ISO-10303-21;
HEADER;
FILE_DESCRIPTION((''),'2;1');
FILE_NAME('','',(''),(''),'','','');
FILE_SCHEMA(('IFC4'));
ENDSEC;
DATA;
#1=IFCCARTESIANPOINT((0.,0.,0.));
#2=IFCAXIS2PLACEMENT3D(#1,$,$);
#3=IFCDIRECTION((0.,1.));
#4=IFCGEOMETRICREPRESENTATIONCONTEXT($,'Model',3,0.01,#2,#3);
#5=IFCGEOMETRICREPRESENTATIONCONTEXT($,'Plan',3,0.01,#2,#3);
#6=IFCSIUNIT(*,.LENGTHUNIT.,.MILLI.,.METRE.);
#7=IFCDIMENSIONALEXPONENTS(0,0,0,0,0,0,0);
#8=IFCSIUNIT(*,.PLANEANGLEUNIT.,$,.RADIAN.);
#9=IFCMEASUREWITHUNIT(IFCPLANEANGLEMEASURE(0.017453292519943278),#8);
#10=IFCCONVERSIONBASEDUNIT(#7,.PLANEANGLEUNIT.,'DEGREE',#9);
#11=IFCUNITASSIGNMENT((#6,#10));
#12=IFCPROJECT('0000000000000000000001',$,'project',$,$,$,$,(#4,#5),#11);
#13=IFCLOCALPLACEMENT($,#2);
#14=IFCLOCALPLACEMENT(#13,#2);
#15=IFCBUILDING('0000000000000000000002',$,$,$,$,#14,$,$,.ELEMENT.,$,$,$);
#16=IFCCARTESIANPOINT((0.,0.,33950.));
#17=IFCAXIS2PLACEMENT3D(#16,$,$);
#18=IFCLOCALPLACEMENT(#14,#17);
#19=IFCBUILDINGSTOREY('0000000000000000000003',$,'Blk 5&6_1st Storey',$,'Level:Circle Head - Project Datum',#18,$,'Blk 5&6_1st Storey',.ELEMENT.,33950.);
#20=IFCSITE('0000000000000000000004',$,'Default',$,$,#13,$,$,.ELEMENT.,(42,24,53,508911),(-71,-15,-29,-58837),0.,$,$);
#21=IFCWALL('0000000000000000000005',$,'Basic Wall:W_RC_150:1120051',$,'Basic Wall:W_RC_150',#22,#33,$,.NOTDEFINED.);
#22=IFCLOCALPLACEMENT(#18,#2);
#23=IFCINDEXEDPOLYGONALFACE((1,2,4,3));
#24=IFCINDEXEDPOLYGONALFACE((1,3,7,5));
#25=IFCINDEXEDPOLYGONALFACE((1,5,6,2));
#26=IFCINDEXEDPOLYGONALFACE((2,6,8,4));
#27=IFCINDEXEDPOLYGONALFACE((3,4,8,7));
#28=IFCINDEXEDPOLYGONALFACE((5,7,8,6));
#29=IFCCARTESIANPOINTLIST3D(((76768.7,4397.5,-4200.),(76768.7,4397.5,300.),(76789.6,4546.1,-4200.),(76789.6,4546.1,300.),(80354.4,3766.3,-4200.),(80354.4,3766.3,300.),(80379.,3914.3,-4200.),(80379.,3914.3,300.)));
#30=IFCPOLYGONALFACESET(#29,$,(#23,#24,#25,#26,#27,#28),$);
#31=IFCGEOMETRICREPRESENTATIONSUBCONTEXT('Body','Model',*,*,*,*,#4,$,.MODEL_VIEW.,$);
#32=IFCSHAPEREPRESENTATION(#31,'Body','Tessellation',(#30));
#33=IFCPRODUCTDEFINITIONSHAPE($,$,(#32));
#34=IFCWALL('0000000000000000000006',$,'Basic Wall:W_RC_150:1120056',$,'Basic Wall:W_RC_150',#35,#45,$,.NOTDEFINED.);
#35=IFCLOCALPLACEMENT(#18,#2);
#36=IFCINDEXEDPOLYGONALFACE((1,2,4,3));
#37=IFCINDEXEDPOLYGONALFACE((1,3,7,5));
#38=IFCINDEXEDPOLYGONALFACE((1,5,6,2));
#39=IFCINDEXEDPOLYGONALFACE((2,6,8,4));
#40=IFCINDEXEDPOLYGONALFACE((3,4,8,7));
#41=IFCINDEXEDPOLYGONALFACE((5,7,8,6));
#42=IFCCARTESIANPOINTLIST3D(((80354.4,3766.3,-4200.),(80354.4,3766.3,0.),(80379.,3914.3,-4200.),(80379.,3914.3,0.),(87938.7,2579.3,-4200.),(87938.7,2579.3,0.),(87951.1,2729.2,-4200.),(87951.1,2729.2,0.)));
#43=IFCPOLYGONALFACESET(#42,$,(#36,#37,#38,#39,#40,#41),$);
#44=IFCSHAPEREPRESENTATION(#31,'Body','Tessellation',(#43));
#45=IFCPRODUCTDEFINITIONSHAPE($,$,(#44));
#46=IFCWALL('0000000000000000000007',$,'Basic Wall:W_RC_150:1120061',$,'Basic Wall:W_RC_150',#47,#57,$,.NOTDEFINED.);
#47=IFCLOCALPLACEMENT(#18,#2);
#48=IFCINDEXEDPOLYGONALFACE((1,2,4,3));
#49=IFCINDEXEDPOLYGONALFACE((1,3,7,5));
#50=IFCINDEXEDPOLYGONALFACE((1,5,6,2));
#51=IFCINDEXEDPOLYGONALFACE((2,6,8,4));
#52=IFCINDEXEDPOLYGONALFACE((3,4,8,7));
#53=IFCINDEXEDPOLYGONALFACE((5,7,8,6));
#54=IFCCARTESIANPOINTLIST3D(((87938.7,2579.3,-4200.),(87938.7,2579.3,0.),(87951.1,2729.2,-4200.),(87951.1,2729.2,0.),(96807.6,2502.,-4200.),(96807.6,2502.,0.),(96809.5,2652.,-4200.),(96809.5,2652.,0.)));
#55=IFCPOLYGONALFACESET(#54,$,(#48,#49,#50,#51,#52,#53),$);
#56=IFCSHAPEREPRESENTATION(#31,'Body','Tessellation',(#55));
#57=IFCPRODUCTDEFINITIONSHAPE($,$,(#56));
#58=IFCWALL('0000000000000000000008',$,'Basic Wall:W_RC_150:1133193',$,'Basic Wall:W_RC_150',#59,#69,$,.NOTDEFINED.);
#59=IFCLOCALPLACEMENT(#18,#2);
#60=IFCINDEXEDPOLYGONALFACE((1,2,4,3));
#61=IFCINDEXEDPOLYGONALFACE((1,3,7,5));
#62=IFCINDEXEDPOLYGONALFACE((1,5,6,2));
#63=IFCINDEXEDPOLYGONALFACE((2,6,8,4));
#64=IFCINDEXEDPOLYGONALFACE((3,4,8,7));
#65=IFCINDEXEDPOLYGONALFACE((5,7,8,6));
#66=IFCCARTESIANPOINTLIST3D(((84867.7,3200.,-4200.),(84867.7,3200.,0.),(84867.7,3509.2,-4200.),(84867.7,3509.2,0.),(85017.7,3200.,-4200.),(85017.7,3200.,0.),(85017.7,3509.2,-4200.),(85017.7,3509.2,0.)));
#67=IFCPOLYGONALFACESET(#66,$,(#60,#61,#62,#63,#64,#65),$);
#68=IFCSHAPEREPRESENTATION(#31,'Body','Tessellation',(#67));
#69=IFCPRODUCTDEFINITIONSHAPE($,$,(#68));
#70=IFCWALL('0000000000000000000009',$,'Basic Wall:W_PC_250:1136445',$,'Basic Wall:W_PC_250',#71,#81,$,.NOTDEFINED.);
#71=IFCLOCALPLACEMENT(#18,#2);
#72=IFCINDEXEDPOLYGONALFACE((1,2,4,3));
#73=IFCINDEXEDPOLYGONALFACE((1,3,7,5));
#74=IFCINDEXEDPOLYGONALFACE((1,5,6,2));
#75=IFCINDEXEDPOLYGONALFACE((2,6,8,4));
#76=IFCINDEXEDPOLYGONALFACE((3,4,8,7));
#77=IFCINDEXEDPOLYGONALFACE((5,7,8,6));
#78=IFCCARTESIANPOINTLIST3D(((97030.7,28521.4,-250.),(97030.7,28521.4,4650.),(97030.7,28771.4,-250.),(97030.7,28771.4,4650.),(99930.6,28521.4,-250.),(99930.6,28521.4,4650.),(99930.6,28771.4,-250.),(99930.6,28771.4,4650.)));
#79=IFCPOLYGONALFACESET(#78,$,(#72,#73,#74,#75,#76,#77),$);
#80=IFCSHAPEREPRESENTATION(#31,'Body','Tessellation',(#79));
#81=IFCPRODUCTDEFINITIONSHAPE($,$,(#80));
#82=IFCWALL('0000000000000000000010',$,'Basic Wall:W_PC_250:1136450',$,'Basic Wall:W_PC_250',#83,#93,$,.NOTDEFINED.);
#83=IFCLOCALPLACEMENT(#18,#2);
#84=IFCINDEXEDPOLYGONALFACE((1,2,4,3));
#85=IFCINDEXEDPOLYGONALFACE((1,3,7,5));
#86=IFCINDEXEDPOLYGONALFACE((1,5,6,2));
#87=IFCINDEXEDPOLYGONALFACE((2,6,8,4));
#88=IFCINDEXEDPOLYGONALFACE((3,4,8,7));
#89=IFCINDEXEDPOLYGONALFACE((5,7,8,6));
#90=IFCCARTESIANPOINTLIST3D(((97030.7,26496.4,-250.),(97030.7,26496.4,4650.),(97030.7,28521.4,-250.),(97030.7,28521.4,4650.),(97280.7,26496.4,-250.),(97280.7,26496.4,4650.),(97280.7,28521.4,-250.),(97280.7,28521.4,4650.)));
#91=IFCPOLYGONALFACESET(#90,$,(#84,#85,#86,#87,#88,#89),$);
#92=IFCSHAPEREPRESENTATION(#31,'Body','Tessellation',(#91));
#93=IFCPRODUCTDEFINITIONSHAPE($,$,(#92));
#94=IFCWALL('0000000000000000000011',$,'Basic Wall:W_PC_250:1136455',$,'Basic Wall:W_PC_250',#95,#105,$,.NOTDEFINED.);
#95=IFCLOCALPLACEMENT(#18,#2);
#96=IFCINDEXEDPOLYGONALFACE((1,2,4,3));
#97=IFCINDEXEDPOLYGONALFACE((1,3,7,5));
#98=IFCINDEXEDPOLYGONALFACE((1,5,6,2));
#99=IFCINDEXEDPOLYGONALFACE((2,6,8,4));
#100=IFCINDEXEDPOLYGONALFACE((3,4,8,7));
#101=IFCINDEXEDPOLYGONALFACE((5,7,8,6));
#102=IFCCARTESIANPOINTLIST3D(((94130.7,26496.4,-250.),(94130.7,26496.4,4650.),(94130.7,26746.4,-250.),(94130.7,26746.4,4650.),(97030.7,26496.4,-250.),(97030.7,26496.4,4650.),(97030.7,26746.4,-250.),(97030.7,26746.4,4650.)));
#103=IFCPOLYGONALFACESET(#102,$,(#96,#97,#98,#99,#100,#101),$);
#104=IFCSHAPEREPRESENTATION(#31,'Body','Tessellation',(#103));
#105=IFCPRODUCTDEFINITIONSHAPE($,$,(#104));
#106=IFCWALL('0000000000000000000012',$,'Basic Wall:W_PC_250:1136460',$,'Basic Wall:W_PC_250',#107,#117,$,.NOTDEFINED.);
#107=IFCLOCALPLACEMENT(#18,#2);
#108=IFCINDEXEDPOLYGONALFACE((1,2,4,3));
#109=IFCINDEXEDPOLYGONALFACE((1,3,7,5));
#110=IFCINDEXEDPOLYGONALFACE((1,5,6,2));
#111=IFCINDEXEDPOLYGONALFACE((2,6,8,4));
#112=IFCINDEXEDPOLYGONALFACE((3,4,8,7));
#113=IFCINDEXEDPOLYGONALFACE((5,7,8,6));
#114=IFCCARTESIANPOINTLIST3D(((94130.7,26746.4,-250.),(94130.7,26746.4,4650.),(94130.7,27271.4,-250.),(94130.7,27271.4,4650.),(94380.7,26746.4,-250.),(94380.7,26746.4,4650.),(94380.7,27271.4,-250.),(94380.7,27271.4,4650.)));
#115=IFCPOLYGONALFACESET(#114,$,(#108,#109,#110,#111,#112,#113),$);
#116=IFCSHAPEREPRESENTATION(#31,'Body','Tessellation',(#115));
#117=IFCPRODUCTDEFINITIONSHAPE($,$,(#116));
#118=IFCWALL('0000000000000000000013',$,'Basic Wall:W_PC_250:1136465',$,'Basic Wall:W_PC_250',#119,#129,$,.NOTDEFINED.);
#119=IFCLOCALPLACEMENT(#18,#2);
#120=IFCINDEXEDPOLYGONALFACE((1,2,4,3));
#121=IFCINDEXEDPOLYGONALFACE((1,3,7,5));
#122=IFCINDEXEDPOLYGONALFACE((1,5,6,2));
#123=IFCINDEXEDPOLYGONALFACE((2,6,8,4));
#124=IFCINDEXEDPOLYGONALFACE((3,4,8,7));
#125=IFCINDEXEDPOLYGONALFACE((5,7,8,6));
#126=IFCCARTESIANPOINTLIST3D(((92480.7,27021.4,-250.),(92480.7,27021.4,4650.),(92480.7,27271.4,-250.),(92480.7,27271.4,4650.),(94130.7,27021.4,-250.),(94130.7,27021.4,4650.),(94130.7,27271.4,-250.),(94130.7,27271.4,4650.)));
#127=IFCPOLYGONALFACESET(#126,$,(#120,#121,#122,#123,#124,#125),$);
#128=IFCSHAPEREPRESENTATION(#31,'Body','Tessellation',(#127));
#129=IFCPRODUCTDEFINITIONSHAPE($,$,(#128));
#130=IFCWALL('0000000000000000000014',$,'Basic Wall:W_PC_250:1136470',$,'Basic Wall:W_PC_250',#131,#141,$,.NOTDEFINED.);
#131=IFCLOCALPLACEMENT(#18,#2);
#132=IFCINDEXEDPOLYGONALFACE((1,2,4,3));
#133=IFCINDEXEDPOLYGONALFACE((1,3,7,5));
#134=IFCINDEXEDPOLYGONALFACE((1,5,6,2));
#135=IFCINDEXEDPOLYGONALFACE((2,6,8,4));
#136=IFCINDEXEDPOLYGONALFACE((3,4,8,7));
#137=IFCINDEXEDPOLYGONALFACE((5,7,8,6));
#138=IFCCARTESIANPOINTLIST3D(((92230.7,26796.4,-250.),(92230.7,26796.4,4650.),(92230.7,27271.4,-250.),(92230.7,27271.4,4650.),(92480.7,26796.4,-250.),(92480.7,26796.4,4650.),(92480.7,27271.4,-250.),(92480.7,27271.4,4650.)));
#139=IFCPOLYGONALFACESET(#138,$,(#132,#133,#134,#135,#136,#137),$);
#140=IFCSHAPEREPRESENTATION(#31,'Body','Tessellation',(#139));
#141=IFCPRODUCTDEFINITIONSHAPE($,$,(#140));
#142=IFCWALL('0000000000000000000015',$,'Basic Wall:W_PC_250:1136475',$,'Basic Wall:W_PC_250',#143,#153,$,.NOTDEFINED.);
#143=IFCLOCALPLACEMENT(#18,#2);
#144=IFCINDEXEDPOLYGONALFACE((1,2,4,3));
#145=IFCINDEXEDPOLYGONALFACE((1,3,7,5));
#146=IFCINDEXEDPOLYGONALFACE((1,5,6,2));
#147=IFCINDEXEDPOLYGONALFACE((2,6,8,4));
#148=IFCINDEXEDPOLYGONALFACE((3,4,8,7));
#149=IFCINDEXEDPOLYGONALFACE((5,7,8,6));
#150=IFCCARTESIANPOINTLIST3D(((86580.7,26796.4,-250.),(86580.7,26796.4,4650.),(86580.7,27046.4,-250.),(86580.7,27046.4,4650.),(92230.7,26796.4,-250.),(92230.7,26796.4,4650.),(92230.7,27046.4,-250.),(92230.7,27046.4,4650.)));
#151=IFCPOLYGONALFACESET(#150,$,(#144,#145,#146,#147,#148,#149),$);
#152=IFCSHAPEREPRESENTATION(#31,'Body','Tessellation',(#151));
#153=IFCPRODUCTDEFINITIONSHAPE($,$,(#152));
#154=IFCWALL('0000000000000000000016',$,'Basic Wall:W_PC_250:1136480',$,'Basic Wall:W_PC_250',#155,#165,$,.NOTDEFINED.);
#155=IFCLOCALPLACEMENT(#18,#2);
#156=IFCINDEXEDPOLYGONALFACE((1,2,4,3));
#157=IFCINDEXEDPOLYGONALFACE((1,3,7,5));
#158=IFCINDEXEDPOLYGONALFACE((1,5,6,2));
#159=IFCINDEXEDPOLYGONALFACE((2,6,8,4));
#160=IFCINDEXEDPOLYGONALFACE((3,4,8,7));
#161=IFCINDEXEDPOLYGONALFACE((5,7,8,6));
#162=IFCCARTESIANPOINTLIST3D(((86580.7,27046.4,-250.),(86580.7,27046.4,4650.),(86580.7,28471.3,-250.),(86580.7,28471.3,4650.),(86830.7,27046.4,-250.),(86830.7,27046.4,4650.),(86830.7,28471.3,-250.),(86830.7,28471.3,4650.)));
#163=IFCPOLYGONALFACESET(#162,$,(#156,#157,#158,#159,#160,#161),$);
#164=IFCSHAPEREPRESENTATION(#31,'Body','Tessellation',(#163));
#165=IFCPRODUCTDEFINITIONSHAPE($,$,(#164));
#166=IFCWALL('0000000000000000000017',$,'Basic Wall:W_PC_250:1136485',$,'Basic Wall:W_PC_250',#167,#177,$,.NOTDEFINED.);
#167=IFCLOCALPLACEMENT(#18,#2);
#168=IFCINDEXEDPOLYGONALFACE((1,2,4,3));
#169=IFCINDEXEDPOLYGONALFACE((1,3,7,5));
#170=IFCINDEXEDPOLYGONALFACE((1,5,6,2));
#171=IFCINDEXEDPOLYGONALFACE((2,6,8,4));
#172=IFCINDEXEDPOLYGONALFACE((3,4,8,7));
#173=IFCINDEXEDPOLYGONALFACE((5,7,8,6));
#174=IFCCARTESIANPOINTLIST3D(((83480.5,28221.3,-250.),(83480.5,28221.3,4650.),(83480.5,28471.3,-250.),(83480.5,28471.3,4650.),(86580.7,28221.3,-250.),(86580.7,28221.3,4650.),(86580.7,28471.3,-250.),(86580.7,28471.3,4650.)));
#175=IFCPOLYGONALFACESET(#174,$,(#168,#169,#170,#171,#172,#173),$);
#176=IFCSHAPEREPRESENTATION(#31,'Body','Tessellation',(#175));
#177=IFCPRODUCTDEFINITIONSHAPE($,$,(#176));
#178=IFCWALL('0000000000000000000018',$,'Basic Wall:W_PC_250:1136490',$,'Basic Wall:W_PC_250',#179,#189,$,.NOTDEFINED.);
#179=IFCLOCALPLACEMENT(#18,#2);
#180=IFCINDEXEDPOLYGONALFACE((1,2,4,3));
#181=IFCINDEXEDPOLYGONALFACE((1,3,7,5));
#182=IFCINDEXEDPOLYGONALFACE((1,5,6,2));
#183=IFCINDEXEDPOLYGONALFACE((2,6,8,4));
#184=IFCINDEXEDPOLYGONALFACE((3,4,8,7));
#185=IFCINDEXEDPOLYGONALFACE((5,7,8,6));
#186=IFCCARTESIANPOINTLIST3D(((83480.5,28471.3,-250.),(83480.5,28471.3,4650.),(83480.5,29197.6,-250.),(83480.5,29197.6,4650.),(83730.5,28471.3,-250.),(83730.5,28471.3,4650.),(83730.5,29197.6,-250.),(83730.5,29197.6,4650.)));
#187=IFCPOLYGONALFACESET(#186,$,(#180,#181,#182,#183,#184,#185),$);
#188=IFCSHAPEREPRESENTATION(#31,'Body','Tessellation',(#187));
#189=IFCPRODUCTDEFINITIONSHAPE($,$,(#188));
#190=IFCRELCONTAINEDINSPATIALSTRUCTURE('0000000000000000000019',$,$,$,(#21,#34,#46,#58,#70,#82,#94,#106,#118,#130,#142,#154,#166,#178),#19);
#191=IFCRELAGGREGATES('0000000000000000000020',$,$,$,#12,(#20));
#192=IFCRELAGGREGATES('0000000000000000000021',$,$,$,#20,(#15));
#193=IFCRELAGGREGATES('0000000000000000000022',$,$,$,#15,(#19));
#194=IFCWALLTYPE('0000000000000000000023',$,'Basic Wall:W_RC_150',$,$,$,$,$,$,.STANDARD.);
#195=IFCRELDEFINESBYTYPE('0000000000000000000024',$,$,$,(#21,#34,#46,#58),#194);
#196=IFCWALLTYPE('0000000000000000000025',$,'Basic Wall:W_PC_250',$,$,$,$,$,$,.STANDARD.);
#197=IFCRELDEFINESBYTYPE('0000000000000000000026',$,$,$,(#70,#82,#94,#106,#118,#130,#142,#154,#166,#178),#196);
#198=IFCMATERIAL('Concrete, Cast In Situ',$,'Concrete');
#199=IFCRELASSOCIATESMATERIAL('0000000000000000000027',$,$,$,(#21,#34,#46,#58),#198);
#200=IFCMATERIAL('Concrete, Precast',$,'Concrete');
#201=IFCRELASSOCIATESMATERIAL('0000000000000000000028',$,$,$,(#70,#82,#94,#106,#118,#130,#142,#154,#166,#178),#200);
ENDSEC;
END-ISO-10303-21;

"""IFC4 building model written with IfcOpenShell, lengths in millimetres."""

from ifc_helpers import new_model, entity, si_unit, converted_unit, direction, frame, origin, place, context, subcontext, project, spatial, indexed_curve, outline, extrude, material, type_object, element, save


model = new_model("IFC4")

# Units and contexts
model_context = context("Model", 3, precision=0.01, world=origin(), true_north=direction((0.0, 1.0)))
plan_context = context("Plan", 3, precision=0.01, world=origin(), true_north=direction((0.0, 1.0)))
body_context = subcontext(model_context, "Body", "Model", "MODEL_VIEW")
ifc_project = project(units=[si_unit("LENGTHUNIT", "METRE", prefix="MILLI"), converted_unit("PLANEANGLEUNIT", "DEGREE", entity("IfcPlaneAngleMeasure", 0.017453292519943278), si_unit("PLANEANGLEUNIT", "RADIAN"), dimensions=[0, 0, 0, 0, 0, 0, 0])], contexts=[model_context, plan_context])

# Site, building, storey
site_placement = place(None, origin())
site = spatial("IfcSite", under=ifc_project, at=site_placement, Name="Default", CompositionType="ELEMENT", RefLatitude=(42, 24, 53, 508911), RefLongitude=(-71, -15, -29, -58837), RefElevation=0.0)
building_placement = place(site_placement, origin())
building = spatial("IfcBuilding", under=site, at=building_placement, CompositionType="ELEMENT")
storey_placement = place(building_placement, frame((0.0, 0.0, 33950.0)))
storey = spatial("IfcBuildingStorey", under=building, at=storey_placement, Name="Blk 5&6_1st Storey", ObjectType="Level:Circle Head - Project Datum", LongName="Blk 5&6_1st Storey", CompositionType="ELEMENT", Elevation=33950.0)

# Walls
ifc_material_1 = material(Name="Concrete, Cast In Situ", Category="Concrete")
wall_type_1 = type_object("IfcWallType", Name="Basic Wall:W_RC_150", PredefinedType="STANDARD")
wall_1_placement = place(storey_placement, frame((80367.4, 3840.1, -4200.0), z_axis=(0.0, 0.0, 1.0), x_axis=(-0.984855, 0.173377, 0.0)))
element("IfcWall", 1, at=wall_1_placement, inside=storey, type_object=wall_type_1, material=ifc_material_1, Name="Basic Wall:W_RC_150:1120051", ObjectType="Basic Wall:W_RC_150", PredefinedType="NOTDEFINED", context=body_context, shape_type="SweptSolid", body=[
    extrude(outline(indexed_curve([(3646.0, -75.0), (3640.8, 75.0), (0.0, 75.0), (1.4, -75.0), (3646.0, -75.0)], self_intersect=False)), origin(), (0.0, 0.0, 1.0), 4500.0),
])
wall_2_placement = place(storey_placement, frame((87950.3, 2653.4, -4200.0), z_axis=(0.0, 0.0, 1.0), x_axis=(-0.987973, 0.154624, 0.0)))
element("IfcWall", 2, at=wall_2_placement, inside=storey, type_object=wall_type_1, material=ifc_material_1, Name="Basic Wall:W_RC_150:1120056", ObjectType="Basic Wall:W_RC_150", PredefinedType="NOTDEFINED", context=body_context, shape_type="SweptSolid", body=[
    extrude(outline(indexed_curve([(7675.2, -75.0), (7676.6, 75.0), (0.0, 75.0), (11.0, -75.0), (7675.2, -75.0)], self_intersect=False)), origin(), (0.0, 0.0, 1.0), 4200.0),
])
wall_3_placement = place(storey_placement, frame((96808.9, 2577.0, -4200.0), z_axis=(0.0, 0.0, 1.0), x_axis=(-0.999962, 0.008716, 0.0)))
element("IfcWall", 3, at=wall_3_placement, inside=storey, type_object=wall_type_1, material=ifc_material_1, Name="Basic Wall:W_RC_150:1120061", ObjectType="Basic Wall:W_RC_150", PredefinedType="NOTDEFINED", context=body_context, shape_type="SweptSolid", body=[
    extrude(outline(indexed_curve([(8858.8, -75.0), (8869.8, 75.0), (0.6, 75.0), (0.0, -75.0), (8858.8, -75.0)], self_intersect=False)), origin(), (0.0, 0.0, 1.0), 4200.0),
])
wall_4_placement = place(storey_placement, frame((84942.7, 3509.2, -4200.0), z_axis=(0.0, 0.0, 1.0), x_axis=(0.0, -1.0, 0.0)))
element("IfcWall", 4, at=wall_4_placement, inside=storey, type_object=wall_type_1, material=ifc_material_1, Name="Basic Wall:W_RC_150:1133193", ObjectType="Basic Wall:W_RC_150", PredefinedType="NOTDEFINED", context=body_context, shape_type="SweptSolid", body=[
    extrude(outline(indexed_curve([(309.2, 75.0), (0.0, 75.0), (0.0, -75.0), (309.2, -75.0), (309.2, 75.0)], self_intersect=False)), origin(), (0.0, 0.0, 1.0), 4200.0),
])
ifc_material_2 = material(Name="Concrete, Precast", Category="Concrete")
wall_type_2 = type_object("IfcWallType", Name="Basic Wall:W_PC_250", PredefinedType="STANDARD")
wall_5_placement = place(storey_placement, frame((99930.6, 28646.4, -250.0), z_axis=(0.0, 0.0, 1.0), x_axis=(-1.0, 0.0, 0.0)))
element("IfcWall", 5, at=wall_5_placement, inside=storey, type_object=wall_type_2, material=ifc_material_2, Name="Basic Wall:W_PC_250:1136445", ObjectType="Basic Wall:W_PC_250", PredefinedType="NOTDEFINED", context=body_context, shape_type="SweptSolid", body=[
    extrude(outline(indexed_curve([(2900.0, 125.0), (0.0, 125.0), (0.0, -125.0), (2900.0, -125.0), (2900.0, 125.0)], self_intersect=False)), origin(), (0.0, 0.0, 1.0), 4900.0),
])
wall_6_placement = place(storey_placement, frame((97155.7, 28521.4, -250.0), z_axis=(0.0, 0.0, 1.0), x_axis=(0.0, -1.0, 0.0)))
element("IfcWall", 6, at=wall_6_placement, inside=storey, type_object=wall_type_2, material=ifc_material_2, Name="Basic Wall:W_PC_250:1136450", ObjectType="Basic Wall:W_PC_250", PredefinedType="NOTDEFINED", context=body_context, shape_type="SweptSolid", body=[
    extrude(outline(indexed_curve([(2025.0, 125.0), (0.0, 125.0), (0.0, -125.0), (2025.0, -125.0), (2025.0, 125.0)], self_intersect=False)), origin(), (0.0, 0.0, 1.0), 4900.0),
])
wall_7_placement = place(storey_placement, frame((97030.7, 26621.4, -250.0), z_axis=(0.0, 0.0, 1.0), x_axis=(-1.0, 0.0, 0.0)))
element("IfcWall", 7, at=wall_7_placement, inside=storey, type_object=wall_type_2, material=ifc_material_2, Name="Basic Wall:W_PC_250:1136455", ObjectType="Basic Wall:W_PC_250", PredefinedType="NOTDEFINED", context=body_context, shape_type="SweptSolid", body=[
    extrude(outline(indexed_curve([(2900.0, 125.0), (0.0, 125.0), (0.0, -125.0), (2900.0, -125.0), (2900.0, 125.0)], self_intersect=False)), origin(), (0.0, 0.0, 1.0), 4900.0),
])
wall_8_placement = place(storey_placement, frame((94255.7, 26746.4, -250.0), z_axis=(0.0, 0.0, 1.0), x_axis=(0.0, 1.0, 0.0)))
element("IfcWall", 8, at=wall_8_placement, inside=storey, type_object=wall_type_2, material=ifc_material_2, Name="Basic Wall:W_PC_250:1136460", ObjectType="Basic Wall:W_PC_250", PredefinedType="NOTDEFINED", context=body_context, shape_type="SweptSolid", body=[
    extrude(outline(indexed_curve([(525.0, 125.0), (0.0, 125.0), (0.0, -125.0), (525.0, -125.0), (525.0, 125.0)], self_intersect=False)), origin(), (0.0, 0.0, 1.0), 4900.0),
])
wall_9_placement = place(storey_placement, frame((94130.7, 27146.4, -250.0), z_axis=(0.0, 0.0, 1.0), x_axis=(-1.0, 0.0, 0.0)))
element("IfcWall", 9, at=wall_9_placement, inside=storey, type_object=wall_type_2, material=ifc_material_2, Name="Basic Wall:W_PC_250:1136465", ObjectType="Basic Wall:W_PC_250", PredefinedType="NOTDEFINED", context=body_context, shape_type="SweptSolid", body=[
    extrude(outline(indexed_curve([(1650.0, 125.0), (0.0, 125.0), (0.0, -125.0), (1650.0, -125.0), (1650.0, 125.0)], self_intersect=False)), origin(), (0.0, 0.0, 1.0), 4900.0),
])
wall_10_placement = place(storey_placement, frame((92355.7, 27271.4, -250.0), z_axis=(0.0, 0.0, 1.0), x_axis=(0.0, -1.0, 0.0)))
element("IfcWall", 10, at=wall_10_placement, inside=storey, type_object=wall_type_2, material=ifc_material_2, Name="Basic Wall:W_PC_250:1136470", ObjectType="Basic Wall:W_PC_250", PredefinedType="NOTDEFINED", context=body_context, shape_type="SweptSolid", body=[
    extrude(outline(indexed_curve([(475.0, 125.0), (0.0, 125.0), (0.0, -125.0), (475.0, -125.0), (475.0, 125.0)], self_intersect=False)), origin(), (0.0, 0.0, 1.0), 4900.0),
])
wall_11_placement = place(storey_placement, frame((92230.7, 26921.4, -250.0), z_axis=(0.0, 0.0, 1.0), x_axis=(-1.0, 0.0, 0.0)))
element("IfcWall", 11, at=wall_11_placement, inside=storey, type_object=wall_type_2, material=ifc_material_2, Name="Basic Wall:W_PC_250:1136475", ObjectType="Basic Wall:W_PC_250", PredefinedType="NOTDEFINED", context=body_context, shape_type="SweptSolid", body=[
    extrude(outline(indexed_curve([(5650.0, 125.0), (0.0, 125.0), (0.0, -125.0), (5650.0, -125.0), (5650.0, 125.0)], self_intersect=False)), origin(), (0.0, 0.0, 1.0), 4900.0),
])
wall_12_placement = place(storey_placement, frame((86705.7, 27046.4, -250.0), z_axis=(0.0, 0.0, 1.0), x_axis=(0.0, 1.0, 0.0)))
element("IfcWall", 12, at=wall_12_placement, inside=storey, type_object=wall_type_2, material=ifc_material_2, Name="Basic Wall:W_PC_250:1136480", ObjectType="Basic Wall:W_PC_250", PredefinedType="NOTDEFINED", context=body_context, shape_type="SweptSolid", body=[
    extrude(outline(indexed_curve([(1424.9, 125.0), (0.0, 125.0), (0.0, -125.0), (1424.9, -125.0), (1424.9, 125.0)], self_intersect=False)), origin(), (0.0, 0.0, 1.0), 4900.0),
])
wall_13_placement = place(storey_placement, frame((86580.7, 28346.3, -250.0), z_axis=(0.0, 0.0, 1.0), x_axis=(-1.0, 0.0, 0.0)))
element("IfcWall", 13, at=wall_13_placement, inside=storey, type_object=wall_type_2, material=ifc_material_2, Name="Basic Wall:W_PC_250:1136485", ObjectType="Basic Wall:W_PC_250", PredefinedType="NOTDEFINED", context=body_context, shape_type="SweptSolid", body=[
    extrude(outline(indexed_curve([(3100.2, 125.0), (0.0, 125.0), (0.0, -125.0), (3100.2, -125.0), (3100.2, 125.0)], self_intersect=False)), origin(), (0.0, 0.0, 1.0), 4900.0),
])
wall_14_placement = place(storey_placement, frame((83605.5, 28471.3, -250.0), z_axis=(0.0, 0.0, 1.0), x_axis=(0.0, 1.0, 0.0)))
element("IfcWall", 14, at=wall_14_placement, inside=storey, type_object=wall_type_2, material=ifc_material_2, Name="Basic Wall:W_PC_250:1136490", ObjectType="Basic Wall:W_PC_250", PredefinedType="NOTDEFINED", context=body_context, shape_type="SweptSolid", body=[
    extrude(outline(indexed_curve([(726.3, 125.0), (0.0, 125.0), (0.0, -125.0), (726.3, -125.0), (726.3, 125.0)], self_intersect=False)), origin(), (0.0, 0.0, 1.0), 4900.0),
])

save(model, "model.ifc")
